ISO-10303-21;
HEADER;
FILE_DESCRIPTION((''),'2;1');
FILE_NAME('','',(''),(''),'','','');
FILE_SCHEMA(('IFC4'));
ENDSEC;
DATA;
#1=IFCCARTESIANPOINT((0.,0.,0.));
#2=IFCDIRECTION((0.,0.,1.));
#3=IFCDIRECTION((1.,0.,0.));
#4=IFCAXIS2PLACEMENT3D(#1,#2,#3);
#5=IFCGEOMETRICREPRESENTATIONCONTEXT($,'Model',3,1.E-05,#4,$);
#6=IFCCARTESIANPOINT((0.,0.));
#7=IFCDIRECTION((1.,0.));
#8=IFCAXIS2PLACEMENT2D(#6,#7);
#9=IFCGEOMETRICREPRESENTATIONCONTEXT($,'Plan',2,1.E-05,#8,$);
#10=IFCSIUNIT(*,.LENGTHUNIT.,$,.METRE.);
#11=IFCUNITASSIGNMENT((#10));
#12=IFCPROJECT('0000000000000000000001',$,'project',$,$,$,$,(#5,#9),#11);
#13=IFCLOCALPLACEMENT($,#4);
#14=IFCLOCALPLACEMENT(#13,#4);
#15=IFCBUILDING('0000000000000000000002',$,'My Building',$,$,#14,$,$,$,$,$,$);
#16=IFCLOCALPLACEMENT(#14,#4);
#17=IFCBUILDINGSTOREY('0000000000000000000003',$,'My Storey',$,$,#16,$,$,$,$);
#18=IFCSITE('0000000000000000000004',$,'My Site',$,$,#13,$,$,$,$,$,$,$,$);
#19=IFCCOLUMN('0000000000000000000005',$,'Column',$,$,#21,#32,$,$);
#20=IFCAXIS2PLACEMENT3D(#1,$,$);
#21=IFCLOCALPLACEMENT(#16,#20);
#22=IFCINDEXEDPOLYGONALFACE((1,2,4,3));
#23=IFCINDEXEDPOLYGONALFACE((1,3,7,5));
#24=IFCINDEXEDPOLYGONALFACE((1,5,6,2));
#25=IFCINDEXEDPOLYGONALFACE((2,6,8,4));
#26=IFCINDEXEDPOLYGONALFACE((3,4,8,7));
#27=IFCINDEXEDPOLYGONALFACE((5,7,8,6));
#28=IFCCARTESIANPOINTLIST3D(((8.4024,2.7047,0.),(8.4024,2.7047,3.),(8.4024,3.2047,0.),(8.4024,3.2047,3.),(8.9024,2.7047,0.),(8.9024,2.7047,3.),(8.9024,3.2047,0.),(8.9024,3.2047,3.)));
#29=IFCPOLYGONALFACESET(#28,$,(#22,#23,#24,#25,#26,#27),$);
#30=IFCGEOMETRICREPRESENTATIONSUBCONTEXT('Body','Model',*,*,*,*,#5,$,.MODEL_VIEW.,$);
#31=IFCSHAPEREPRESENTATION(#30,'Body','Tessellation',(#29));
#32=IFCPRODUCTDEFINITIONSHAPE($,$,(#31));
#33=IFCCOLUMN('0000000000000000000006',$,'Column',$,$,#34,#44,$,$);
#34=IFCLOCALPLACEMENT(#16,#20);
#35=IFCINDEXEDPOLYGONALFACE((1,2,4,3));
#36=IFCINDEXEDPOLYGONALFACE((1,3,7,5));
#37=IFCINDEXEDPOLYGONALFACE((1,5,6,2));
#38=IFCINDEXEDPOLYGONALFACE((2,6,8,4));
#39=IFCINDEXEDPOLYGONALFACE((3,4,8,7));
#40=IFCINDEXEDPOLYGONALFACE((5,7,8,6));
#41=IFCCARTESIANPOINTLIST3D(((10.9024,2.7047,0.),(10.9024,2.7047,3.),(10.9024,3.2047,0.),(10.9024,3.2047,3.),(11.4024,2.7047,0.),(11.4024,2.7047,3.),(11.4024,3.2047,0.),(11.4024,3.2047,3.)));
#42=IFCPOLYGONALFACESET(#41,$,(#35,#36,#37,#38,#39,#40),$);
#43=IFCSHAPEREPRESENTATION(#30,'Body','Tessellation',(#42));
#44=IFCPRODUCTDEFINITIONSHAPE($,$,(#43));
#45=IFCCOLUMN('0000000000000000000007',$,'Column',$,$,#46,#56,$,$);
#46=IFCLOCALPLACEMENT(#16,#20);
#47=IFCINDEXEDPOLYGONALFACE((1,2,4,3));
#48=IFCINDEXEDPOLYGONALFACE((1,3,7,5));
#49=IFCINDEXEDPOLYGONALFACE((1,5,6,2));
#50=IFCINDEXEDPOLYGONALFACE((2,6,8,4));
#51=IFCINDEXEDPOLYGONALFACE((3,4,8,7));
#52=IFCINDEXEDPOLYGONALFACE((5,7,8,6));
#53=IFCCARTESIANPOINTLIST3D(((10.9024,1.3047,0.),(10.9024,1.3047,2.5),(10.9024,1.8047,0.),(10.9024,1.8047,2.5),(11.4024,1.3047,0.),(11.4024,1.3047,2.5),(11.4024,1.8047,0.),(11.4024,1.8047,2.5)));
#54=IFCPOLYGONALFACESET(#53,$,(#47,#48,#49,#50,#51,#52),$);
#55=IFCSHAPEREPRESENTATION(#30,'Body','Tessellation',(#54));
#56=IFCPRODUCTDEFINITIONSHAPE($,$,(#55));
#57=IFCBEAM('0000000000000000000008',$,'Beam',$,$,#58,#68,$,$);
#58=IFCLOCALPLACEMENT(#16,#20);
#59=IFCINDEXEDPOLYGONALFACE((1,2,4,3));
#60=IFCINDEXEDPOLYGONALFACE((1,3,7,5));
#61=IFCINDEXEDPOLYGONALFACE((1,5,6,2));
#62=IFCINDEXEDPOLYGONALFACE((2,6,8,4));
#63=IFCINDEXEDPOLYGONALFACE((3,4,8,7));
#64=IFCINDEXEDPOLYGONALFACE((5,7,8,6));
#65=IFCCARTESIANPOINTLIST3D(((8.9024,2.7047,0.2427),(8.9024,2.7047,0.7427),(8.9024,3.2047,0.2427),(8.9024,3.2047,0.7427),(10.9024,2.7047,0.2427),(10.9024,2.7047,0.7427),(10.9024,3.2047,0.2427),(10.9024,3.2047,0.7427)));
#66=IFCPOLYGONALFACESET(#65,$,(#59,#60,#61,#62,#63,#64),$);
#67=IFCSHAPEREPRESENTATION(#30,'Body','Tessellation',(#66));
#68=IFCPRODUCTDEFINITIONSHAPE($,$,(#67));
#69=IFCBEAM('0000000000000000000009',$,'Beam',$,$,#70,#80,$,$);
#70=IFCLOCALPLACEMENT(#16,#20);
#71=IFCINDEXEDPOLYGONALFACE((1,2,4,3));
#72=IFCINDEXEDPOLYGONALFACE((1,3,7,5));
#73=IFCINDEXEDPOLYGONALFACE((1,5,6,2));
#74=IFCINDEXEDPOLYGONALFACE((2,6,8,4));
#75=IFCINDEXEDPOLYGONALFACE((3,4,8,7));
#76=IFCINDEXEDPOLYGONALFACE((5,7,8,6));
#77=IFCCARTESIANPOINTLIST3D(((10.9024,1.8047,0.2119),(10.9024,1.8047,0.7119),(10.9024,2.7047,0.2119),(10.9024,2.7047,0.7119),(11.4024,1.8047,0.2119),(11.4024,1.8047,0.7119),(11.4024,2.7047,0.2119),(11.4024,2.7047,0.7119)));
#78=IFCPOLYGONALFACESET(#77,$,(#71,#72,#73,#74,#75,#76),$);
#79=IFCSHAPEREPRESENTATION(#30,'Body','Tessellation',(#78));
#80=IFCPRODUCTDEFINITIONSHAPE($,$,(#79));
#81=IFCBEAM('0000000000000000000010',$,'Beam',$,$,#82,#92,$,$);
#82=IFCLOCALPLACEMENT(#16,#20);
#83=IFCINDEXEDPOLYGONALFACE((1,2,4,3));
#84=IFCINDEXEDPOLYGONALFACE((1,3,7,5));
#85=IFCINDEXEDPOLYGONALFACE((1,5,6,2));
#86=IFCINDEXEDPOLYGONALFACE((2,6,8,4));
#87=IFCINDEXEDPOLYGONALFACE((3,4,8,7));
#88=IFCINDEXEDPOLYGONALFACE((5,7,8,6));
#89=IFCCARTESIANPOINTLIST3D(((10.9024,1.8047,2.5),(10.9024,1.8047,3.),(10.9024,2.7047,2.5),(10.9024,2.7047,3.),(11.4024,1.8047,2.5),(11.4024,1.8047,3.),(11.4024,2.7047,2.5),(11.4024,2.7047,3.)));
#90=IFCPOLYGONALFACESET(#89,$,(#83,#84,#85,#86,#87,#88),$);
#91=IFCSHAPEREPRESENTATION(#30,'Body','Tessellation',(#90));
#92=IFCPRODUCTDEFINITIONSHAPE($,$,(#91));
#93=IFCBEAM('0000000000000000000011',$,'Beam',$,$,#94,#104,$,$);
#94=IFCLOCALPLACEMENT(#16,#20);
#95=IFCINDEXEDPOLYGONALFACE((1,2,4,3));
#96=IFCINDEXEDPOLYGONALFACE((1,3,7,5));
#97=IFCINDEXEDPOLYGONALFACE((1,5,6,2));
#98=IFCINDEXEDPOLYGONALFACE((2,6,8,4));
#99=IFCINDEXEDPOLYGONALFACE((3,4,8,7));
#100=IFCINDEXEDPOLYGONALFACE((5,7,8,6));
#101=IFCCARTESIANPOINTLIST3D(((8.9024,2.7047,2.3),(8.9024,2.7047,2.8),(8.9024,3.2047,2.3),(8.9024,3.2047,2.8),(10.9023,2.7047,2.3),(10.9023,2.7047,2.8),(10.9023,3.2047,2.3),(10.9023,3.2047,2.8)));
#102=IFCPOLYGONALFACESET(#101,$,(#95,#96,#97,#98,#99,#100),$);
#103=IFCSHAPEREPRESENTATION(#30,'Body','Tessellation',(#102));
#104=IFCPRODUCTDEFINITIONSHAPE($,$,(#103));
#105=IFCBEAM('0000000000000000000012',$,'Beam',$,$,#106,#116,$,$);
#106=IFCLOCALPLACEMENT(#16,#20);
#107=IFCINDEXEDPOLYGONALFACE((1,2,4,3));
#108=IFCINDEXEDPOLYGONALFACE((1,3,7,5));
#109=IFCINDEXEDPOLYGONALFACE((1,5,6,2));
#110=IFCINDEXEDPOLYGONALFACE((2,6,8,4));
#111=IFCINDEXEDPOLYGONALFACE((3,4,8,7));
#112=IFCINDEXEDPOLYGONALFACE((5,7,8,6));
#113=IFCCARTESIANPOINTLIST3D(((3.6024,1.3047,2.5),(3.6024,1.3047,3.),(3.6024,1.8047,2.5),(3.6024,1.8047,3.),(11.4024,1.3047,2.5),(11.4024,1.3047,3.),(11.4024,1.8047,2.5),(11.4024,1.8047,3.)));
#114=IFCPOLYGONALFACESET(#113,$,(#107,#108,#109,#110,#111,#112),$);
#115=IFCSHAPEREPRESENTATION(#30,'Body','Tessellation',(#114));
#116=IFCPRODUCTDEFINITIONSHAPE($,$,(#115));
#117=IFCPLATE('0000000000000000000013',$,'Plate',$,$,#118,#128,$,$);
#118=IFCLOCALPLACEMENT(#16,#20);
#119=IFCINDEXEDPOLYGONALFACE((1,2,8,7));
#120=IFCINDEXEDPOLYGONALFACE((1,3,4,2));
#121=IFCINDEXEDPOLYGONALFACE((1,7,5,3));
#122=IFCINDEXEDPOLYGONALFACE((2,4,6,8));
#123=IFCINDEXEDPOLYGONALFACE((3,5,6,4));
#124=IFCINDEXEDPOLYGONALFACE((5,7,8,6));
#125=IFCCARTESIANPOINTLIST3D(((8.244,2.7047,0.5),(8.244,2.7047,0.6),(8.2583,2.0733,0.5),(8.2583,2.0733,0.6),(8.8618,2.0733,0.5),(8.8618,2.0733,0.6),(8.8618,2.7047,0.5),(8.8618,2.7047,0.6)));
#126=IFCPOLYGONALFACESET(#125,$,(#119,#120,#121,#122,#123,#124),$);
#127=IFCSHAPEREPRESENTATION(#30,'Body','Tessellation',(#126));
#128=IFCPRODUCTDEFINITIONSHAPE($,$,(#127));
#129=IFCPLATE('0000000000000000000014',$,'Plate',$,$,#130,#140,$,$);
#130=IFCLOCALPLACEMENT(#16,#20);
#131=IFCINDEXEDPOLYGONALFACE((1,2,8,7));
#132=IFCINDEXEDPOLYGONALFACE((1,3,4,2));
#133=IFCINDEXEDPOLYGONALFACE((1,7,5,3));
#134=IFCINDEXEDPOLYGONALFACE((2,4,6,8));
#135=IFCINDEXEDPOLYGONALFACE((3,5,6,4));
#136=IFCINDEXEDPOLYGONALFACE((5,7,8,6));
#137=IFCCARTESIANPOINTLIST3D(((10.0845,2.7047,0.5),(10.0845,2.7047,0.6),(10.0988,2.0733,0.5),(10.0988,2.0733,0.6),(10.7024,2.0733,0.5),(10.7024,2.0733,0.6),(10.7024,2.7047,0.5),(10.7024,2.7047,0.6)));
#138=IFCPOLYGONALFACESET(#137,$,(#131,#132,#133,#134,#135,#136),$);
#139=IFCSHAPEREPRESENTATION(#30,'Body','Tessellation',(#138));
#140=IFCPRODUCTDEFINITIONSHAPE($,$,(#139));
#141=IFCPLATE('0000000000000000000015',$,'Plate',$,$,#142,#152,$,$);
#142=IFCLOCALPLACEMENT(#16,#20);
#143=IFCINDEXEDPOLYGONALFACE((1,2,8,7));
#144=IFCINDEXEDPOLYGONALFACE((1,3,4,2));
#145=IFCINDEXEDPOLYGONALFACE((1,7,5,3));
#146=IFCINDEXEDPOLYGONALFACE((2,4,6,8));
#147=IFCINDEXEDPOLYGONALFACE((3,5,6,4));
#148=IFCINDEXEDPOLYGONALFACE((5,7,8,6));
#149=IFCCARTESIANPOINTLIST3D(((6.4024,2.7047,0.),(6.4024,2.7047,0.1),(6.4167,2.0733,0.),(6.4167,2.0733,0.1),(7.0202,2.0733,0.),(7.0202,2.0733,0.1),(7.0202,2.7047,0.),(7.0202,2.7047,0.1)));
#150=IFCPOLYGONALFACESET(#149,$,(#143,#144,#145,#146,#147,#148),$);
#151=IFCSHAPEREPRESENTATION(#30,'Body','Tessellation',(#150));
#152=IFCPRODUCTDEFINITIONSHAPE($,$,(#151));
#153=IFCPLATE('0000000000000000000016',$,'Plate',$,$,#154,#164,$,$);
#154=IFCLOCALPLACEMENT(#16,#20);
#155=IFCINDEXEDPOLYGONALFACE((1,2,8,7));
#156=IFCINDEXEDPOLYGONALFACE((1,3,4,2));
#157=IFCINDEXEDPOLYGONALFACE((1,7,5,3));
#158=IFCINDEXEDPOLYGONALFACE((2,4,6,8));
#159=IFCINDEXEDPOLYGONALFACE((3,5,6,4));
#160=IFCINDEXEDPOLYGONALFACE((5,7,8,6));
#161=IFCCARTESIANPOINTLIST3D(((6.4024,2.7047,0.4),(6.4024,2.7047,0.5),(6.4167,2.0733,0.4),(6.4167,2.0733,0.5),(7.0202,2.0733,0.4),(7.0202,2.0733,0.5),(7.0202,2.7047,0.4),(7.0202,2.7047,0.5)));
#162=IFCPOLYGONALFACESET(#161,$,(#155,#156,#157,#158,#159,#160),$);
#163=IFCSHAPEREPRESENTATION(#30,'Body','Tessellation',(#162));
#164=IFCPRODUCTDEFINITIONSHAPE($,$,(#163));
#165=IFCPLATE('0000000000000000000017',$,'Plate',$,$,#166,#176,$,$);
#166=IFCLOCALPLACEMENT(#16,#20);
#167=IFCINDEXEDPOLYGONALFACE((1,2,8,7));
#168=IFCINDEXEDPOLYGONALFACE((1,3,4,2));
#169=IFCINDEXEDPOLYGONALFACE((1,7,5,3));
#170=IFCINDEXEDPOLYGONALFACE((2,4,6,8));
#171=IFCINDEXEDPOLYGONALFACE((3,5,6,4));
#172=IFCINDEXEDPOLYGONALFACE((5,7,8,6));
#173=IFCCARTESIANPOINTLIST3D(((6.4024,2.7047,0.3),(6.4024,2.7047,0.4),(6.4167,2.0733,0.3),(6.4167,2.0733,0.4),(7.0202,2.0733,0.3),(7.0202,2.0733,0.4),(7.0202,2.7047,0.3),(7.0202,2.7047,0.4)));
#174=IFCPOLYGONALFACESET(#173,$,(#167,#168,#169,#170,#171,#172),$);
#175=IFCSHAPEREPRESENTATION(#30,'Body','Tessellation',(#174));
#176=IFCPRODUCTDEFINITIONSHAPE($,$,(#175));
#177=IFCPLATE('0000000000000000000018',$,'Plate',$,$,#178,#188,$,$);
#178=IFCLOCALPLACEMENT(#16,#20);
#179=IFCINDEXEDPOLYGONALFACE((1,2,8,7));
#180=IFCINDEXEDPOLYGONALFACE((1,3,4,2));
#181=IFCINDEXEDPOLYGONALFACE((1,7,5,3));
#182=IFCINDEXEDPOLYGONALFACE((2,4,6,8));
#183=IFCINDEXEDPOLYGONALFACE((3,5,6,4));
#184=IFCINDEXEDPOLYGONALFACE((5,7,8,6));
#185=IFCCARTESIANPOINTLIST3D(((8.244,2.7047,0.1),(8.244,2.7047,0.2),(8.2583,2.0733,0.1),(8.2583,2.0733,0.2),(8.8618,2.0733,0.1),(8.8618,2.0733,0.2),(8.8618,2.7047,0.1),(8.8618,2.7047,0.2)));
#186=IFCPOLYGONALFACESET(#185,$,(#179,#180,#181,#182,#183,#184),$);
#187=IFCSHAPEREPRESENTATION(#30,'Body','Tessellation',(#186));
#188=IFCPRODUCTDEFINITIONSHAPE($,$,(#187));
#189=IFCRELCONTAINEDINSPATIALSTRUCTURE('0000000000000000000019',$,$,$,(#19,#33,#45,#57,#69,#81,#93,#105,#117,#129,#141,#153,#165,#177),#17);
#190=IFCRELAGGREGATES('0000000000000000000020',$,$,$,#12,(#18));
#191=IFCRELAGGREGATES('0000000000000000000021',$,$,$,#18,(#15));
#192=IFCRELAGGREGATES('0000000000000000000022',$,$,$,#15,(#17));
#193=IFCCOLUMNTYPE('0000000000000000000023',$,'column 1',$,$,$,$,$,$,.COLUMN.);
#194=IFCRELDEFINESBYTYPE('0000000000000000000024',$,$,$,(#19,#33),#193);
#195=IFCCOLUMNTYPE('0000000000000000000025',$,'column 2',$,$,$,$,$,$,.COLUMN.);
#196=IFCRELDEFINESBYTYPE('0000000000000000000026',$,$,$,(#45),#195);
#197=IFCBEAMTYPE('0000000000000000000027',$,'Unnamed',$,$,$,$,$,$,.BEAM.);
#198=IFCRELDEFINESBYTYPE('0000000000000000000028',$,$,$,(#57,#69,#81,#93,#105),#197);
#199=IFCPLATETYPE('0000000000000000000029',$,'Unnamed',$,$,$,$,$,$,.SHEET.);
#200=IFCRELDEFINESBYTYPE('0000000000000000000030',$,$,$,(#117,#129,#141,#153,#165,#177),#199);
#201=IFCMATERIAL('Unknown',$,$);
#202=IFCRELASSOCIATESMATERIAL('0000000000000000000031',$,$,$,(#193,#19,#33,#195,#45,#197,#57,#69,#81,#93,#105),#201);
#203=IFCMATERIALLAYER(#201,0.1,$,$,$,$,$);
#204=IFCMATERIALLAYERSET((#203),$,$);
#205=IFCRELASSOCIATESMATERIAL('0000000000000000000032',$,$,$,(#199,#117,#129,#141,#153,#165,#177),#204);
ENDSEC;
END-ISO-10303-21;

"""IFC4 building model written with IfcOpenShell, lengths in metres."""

from ifc_helpers import new_model, si_unit, frame, origin_with_axes, origin_2d_with_axis, place, context, subcontext, project, spatial, indexed_curve, rectangle, outline, extrude, material, layer, layer_set, layer_usage, material_profile, profile_set, profile_usage, type_object, element, save


model = new_model("IFC4")

# Units and contexts
model_context = context("Model", 3, precision=1e-05, world=origin_with_axes())
plan_context = context("Plan", 2, precision=1e-05, world=origin_2d_with_axis())
body_context = subcontext(model_context, "Body", "Model", "MODEL_VIEW")
ifc_project = project(units=[si_unit("LENGTHUNIT", "METRE")], contexts=[model_context, plan_context])

# Site, building, storey
site_placement = place(None, origin_with_axes())
site = spatial("IfcSite", under=ifc_project, at=site_placement, Name="My Site")
building_placement = place(site_placement, origin_with_axes())
building = spatial("IfcBuilding", under=site, at=building_placement, Name="My Building")
storey_placement = place(building_placement, origin_with_axes())
storey = spatial("IfcBuildingStorey", under=building, at=storey_placement, Name="My Storey")

# Columns
ifc_material = material(Name="Unknown")
ifc_material_profile_1 = material_profile(ifc_material, rectangle(XDim=0.5, YDim=0.5))
ifc_profile_set_1 = profile_set([ifc_material_profile_1])
ifc_profile_usage_1 = profile_usage(ifc_profile_set_1, cardinal=5)
column_type_1 = type_object("IfcColumnType", Name="column 1", PredefinedType="COLUMN", material=ifc_profile_set_1)
column_1_placement = place(storey_placement, frame((8.6524, 2.9547, 0.0), z_axis=(0.0, 0.0, 1.0), x_axis=(1.0, 0.0, 0.0)))
element("IfcColumn", 1, at=column_1_placement, inside=storey, type_object=column_type_1, material=ifc_profile_usage_1, Name="Column", context=body_context, shape_type="SweptSolid", body=[
    extrude(rectangle(XDim=0.5, YDim=0.5), origin_with_axes(), (0.0, 0.0, 1.0), 3.0),
])
ifc_profile_usage_2 = profile_usage(ifc_profile_set_1, cardinal=5)
column_2_placement = place(storey_placement, frame((11.1524, 2.9547, 0.0), z_axis=(0.0, 0.0, 1.0), x_axis=(1.0, 0.0, 0.0)))
element("IfcColumn", 2, at=column_2_placement, inside=storey, type_object=column_type_1, material=ifc_profile_usage_2, Name="Column", context=body_context, shape_type="SweptSolid", body=[
    extrude(rectangle(XDim=0.5, YDim=0.5), origin_with_axes(), (0.0, 0.0, 1.0), 3.0),
])
ifc_material_profile_2 = material_profile(ifc_material, rectangle(XDim=0.5, YDim=0.5))
ifc_profile_set_2 = profile_set([ifc_material_profile_2])
ifc_profile_usage_3 = profile_usage(ifc_profile_set_2, cardinal=5)
column_type_2 = type_object("IfcColumnType", Name="column 2", PredefinedType="COLUMN", material=ifc_profile_set_2)
column_3_placement = place(storey_placement, frame((11.1524, 1.5547, 0.0), z_axis=(0.0, 0.0, 1.0), x_axis=(1.0, 0.0, 0.0)))
element("IfcColumn", 3, at=column_3_placement, inside=storey, type_object=column_type_2, material=ifc_profile_usage_3, Name="Column", context=body_context, shape_type="SweptSolid", body=[
    extrude(rectangle(XDim=0.5, YDim=0.5), origin_with_axes(), (0.0, 0.0, 1.0), 2.5),
])

# Beams
ifc_material_profile_3 = material_profile(ifc_material, rectangle(XDim=0.5, YDim=0.5))
ifc_profile_set_3 = profile_set([ifc_material_profile_3])
ifc_profile_usage_4 = profile_usage(ifc_profile_set_3, cardinal=5)
beam_type = type_object("IfcBeamType", Name="Unnamed", PredefinedType="BEAM", material=ifc_profile_set_3)
beam_1_placement = place(storey_placement, frame((8.9024, 2.9547, 0.4927), z_axis=(1.0, 0.0, 0.0), x_axis=(0.0, 1.0, 0.0)))
element("IfcBeam", 4, at=beam_1_placement, inside=storey, type_object=beam_type, material=ifc_profile_usage_4, Name="Beam", context=body_context, shape_type="SweptSolid", body=[
    extrude(rectangle(XDim=0.5, YDim=0.5), origin_with_axes(), (0.0, 0.0, 1.0), 2.0),
])
ifc_profile_usage_5 = profile_usage(ifc_profile_set_3, cardinal=5)
beam_2_placement = place(storey_placement, frame((11.1524, 2.7047, 0.4619), z_axis=(0.0, -1.0, 0.0), x_axis=(1.0, 0.0, 0.0)))
element("IfcBeam", 5, at=beam_2_placement, inside=storey, type_object=beam_type, material=ifc_profile_usage_5, Name="Beam", context=body_context, shape_type="SweptSolid", body=[
    extrude(rectangle(XDim=0.5, YDim=0.5), origin_with_axes(), (0.0, 0.0, 1.0), 0.9),
])
ifc_profile_usage_6 = profile_usage(ifc_profile_set_3, cardinal=5)
beam_3_placement = place(storey_placement, frame((11.1524, 2.7047, 2.75), z_axis=(0.0, -1.0, 0.0), x_axis=(1.0, 0.0, 0.0)))
element("IfcBeam", 6, at=beam_3_placement, inside=storey, type_object=beam_type, material=ifc_profile_usage_6, Name="Beam", context=body_context, shape_type="SweptSolid", body=[
    extrude(rectangle(XDim=0.5, YDim=0.5), origin_with_axes(), (0.0, 0.0, 1.0), 0.9),
])
ifc_profile_usage_7 = profile_usage(ifc_profile_set_3, cardinal=5)
beam_4_placement = place(storey_placement, frame((8.9024, 2.9547, 2.55), z_axis=(1.0, 0.0, 0.0), x_axis=(0.0, 1.0, 0.0)))
element("IfcBeam", 7, at=beam_4_placement, inside=storey, type_object=beam_type, material=ifc_profile_usage_7, Name="Beam", context=body_context, shape_type="SweptSolid", body=[
    extrude(rectangle(XDim=0.5, YDim=0.5), origin_with_axes(), (0.0, 0.0, 1.0), 2.0),
])
ifc_profile_usage_8 = profile_usage(ifc_profile_set_3, cardinal=5)
beam_5_placement = place(storey_placement, frame((11.4024, 1.5547, 2.75), z_axis=(-1.0, 0.0, 0.0), x_axis=(0.0, -1.0, 0.0)))
element("IfcBeam", 8, at=beam_5_placement, inside=storey, type_object=beam_type, material=ifc_profile_usage_8, Name="Beam", context=body_context, shape_type="SweptSolid", body=[
    extrude(rectangle(XDim=0.5, YDim=0.5), origin_with_axes(), (0.0, 0.0, 1.0), 7.8),
])

# Plates
ifc_layer_1 = layer(ifc_material, 0.1)
ifc_layer_set_1 = layer_set([ifc_layer_1])
ifc_layer_usage_1 = layer_usage(ifc_layer_set_1, "AXIS3", "POSITIVE", -0.1)
plate_type = type_object("IfcPlateType", Name="Unnamed", PredefinedType="SHEET", material=ifc_layer_set_1)
plate_1_placement = place(storey_placement, frame((8.2583, 2.0733, 0.6), z_axis=(0.0, 0.0, 1.0), x_axis=(1.0, 0.0, 0.0)))
element("IfcPlate", 9, at=plate_1_placement, inside=storey, type_object=plate_type, material=ifc_layer_usage_1, Name="Plate", context=body_context, shape_type="SweptSolid", body=[
    extrude(outline(indexed_curve([(0.0, 0.0), (0.6036, 0.0), (0.6036, 0.6314), (-0.0143, 0.6314), (0.0, 0.0)])), frame((0.0, 0.0, -0.1), z_axis=(0.0, 0.0, 1.0), x_axis=(1.0, 0.0, 0.0)), (0.0, 0.0, 1.0), 0.1),
])
ifc_layer_usage_2 = layer_usage(ifc_layer_set_1, "AXIS3", "POSITIVE", -0.1)
plate_2_placement = place(storey_placement, frame((10.0988, 2.0733, 0.6), z_axis=(0.0, 0.0, 1.0), x_axis=(1.0, 0.0, 0.0)))
element("IfcPlate", 10, at=plate_2_placement, inside=storey, type_object=plate_type, material=ifc_layer_usage_2, Name="Plate", context=body_context, shape_type="SweptSolid", body=[
    extrude(outline(indexed_curve([(0.0, 0.0), (0.6036, 0.0), (0.6036, 0.6314), (-0.0143, 0.6314), (0.0, 0.0)])), frame((0.0, 0.0, -0.1), z_axis=(0.0, 0.0, 1.0), x_axis=(1.0, 0.0, 0.0)), (0.0, 0.0, 1.0), 0.1),
])
ifc_layer_usage_3 = layer_usage(ifc_layer_set_1, "AXIS3", "POSITIVE", -0.1)
plate_3_placement = place(storey_placement, frame((6.4167, 2.0733, 0.1), z_axis=(0.0, 0.0, 1.0), x_axis=(1.0, 0.0, 0.0)))
element("IfcPlate", 11, at=plate_3_placement, inside=storey, type_object=plate_type, material=ifc_layer_usage_3, Name="Plate", context=body_context, shape_type="SweptSolid", body=[
    extrude(outline(indexed_curve([(0.0, 0.0), (0.6036, 0.0), (0.6036, 0.6314), (-0.0143, 0.6314), (0.0, 0.0)])), frame((0.0, 0.0, -0.1), z_axis=(0.0, 0.0, 1.0), x_axis=(1.0, 0.0, 0.0)), (0.0, 0.0, 1.0), 0.1),
])
ifc_layer_usage_4 = layer_usage(ifc_layer_set_1, "AXIS3", "POSITIVE", -0.1)
plate_4_placement = place(storey_placement, frame((6.4167, 2.0733, 0.5), z_axis=(0.0, 0.0, 1.0), x_axis=(1.0, 0.0, 0.0)))
element("IfcPlate", 12, at=plate_4_placement, inside=storey, type_object=plate_type, material=ifc_layer_usage_4, Name="Plate", context=body_context, shape_type="SweptSolid", body=[
    extrude(outline(indexed_curve([(0.0, 0.0), (0.6036, 0.0), (0.6036, 0.6314), (-0.0143, 0.6314), (0.0, 0.0)])), frame((0.0, 0.0, -0.1), z_axis=(0.0, 0.0, 1.0), x_axis=(1.0, 0.0, 0.0)), (0.0, 0.0, 1.0), 0.1),
])
ifc_layer_usage_5 = layer_usage(ifc_layer_set_1, "AXIS3", "POSITIVE", -0.1)
plate_5_placement = place(storey_placement, frame((6.4167, 2.0733, 0.4), z_axis=(0.0, 0.0, 1.0), x_axis=(1.0, 0.0, 0.0)))
element("IfcPlate", 13, at=plate_5_placement, inside=storey, type_object=plate_type, material=ifc_layer_usage_5, Name="Plate", context=body_context, shape_type="SweptSolid", body=[
    extrude(outline(indexed_curve([(0.0, 0.0), (0.6036, 0.0), (0.6036, 0.6314), (-0.0143, 0.6314), (0.0, 0.0)])), frame((0.0, 0.0, -0.1), z_axis=(0.0, 0.0, 1.0), x_axis=(1.0, 0.0, 0.0)), (0.0, 0.0, 1.0), 0.1),
])
ifc_layer_usage_6 = layer_usage(ifc_layer_set_1, "AXIS3", "POSITIVE", -0.1)
plate_6_placement = place(storey_placement, frame((8.2583, 2.0733, 0.2), z_axis=(0.0, 0.0, 1.0), x_axis=(1.0, 0.0, 0.0)))
element("IfcPlate", 14, at=plate_6_placement, inside=storey, type_object=plate_type, material=ifc_layer_usage_6, Name="Plate", context=body_context, shape_type="SweptSolid", body=[
    extrude(outline(indexed_curve([(0.0, 0.0), (0.6036, 0.0), (0.6036, 0.6314), (-0.0143, 0.6314), (0.0, 0.0)])), frame((0.0, 0.0, -0.1), z_axis=(0.0, 0.0, 1.0), x_axis=(1.0, 0.0, 0.0)), (0.0, 0.0, 1.0), 0.1),
])

save(model, "model.ifc")
